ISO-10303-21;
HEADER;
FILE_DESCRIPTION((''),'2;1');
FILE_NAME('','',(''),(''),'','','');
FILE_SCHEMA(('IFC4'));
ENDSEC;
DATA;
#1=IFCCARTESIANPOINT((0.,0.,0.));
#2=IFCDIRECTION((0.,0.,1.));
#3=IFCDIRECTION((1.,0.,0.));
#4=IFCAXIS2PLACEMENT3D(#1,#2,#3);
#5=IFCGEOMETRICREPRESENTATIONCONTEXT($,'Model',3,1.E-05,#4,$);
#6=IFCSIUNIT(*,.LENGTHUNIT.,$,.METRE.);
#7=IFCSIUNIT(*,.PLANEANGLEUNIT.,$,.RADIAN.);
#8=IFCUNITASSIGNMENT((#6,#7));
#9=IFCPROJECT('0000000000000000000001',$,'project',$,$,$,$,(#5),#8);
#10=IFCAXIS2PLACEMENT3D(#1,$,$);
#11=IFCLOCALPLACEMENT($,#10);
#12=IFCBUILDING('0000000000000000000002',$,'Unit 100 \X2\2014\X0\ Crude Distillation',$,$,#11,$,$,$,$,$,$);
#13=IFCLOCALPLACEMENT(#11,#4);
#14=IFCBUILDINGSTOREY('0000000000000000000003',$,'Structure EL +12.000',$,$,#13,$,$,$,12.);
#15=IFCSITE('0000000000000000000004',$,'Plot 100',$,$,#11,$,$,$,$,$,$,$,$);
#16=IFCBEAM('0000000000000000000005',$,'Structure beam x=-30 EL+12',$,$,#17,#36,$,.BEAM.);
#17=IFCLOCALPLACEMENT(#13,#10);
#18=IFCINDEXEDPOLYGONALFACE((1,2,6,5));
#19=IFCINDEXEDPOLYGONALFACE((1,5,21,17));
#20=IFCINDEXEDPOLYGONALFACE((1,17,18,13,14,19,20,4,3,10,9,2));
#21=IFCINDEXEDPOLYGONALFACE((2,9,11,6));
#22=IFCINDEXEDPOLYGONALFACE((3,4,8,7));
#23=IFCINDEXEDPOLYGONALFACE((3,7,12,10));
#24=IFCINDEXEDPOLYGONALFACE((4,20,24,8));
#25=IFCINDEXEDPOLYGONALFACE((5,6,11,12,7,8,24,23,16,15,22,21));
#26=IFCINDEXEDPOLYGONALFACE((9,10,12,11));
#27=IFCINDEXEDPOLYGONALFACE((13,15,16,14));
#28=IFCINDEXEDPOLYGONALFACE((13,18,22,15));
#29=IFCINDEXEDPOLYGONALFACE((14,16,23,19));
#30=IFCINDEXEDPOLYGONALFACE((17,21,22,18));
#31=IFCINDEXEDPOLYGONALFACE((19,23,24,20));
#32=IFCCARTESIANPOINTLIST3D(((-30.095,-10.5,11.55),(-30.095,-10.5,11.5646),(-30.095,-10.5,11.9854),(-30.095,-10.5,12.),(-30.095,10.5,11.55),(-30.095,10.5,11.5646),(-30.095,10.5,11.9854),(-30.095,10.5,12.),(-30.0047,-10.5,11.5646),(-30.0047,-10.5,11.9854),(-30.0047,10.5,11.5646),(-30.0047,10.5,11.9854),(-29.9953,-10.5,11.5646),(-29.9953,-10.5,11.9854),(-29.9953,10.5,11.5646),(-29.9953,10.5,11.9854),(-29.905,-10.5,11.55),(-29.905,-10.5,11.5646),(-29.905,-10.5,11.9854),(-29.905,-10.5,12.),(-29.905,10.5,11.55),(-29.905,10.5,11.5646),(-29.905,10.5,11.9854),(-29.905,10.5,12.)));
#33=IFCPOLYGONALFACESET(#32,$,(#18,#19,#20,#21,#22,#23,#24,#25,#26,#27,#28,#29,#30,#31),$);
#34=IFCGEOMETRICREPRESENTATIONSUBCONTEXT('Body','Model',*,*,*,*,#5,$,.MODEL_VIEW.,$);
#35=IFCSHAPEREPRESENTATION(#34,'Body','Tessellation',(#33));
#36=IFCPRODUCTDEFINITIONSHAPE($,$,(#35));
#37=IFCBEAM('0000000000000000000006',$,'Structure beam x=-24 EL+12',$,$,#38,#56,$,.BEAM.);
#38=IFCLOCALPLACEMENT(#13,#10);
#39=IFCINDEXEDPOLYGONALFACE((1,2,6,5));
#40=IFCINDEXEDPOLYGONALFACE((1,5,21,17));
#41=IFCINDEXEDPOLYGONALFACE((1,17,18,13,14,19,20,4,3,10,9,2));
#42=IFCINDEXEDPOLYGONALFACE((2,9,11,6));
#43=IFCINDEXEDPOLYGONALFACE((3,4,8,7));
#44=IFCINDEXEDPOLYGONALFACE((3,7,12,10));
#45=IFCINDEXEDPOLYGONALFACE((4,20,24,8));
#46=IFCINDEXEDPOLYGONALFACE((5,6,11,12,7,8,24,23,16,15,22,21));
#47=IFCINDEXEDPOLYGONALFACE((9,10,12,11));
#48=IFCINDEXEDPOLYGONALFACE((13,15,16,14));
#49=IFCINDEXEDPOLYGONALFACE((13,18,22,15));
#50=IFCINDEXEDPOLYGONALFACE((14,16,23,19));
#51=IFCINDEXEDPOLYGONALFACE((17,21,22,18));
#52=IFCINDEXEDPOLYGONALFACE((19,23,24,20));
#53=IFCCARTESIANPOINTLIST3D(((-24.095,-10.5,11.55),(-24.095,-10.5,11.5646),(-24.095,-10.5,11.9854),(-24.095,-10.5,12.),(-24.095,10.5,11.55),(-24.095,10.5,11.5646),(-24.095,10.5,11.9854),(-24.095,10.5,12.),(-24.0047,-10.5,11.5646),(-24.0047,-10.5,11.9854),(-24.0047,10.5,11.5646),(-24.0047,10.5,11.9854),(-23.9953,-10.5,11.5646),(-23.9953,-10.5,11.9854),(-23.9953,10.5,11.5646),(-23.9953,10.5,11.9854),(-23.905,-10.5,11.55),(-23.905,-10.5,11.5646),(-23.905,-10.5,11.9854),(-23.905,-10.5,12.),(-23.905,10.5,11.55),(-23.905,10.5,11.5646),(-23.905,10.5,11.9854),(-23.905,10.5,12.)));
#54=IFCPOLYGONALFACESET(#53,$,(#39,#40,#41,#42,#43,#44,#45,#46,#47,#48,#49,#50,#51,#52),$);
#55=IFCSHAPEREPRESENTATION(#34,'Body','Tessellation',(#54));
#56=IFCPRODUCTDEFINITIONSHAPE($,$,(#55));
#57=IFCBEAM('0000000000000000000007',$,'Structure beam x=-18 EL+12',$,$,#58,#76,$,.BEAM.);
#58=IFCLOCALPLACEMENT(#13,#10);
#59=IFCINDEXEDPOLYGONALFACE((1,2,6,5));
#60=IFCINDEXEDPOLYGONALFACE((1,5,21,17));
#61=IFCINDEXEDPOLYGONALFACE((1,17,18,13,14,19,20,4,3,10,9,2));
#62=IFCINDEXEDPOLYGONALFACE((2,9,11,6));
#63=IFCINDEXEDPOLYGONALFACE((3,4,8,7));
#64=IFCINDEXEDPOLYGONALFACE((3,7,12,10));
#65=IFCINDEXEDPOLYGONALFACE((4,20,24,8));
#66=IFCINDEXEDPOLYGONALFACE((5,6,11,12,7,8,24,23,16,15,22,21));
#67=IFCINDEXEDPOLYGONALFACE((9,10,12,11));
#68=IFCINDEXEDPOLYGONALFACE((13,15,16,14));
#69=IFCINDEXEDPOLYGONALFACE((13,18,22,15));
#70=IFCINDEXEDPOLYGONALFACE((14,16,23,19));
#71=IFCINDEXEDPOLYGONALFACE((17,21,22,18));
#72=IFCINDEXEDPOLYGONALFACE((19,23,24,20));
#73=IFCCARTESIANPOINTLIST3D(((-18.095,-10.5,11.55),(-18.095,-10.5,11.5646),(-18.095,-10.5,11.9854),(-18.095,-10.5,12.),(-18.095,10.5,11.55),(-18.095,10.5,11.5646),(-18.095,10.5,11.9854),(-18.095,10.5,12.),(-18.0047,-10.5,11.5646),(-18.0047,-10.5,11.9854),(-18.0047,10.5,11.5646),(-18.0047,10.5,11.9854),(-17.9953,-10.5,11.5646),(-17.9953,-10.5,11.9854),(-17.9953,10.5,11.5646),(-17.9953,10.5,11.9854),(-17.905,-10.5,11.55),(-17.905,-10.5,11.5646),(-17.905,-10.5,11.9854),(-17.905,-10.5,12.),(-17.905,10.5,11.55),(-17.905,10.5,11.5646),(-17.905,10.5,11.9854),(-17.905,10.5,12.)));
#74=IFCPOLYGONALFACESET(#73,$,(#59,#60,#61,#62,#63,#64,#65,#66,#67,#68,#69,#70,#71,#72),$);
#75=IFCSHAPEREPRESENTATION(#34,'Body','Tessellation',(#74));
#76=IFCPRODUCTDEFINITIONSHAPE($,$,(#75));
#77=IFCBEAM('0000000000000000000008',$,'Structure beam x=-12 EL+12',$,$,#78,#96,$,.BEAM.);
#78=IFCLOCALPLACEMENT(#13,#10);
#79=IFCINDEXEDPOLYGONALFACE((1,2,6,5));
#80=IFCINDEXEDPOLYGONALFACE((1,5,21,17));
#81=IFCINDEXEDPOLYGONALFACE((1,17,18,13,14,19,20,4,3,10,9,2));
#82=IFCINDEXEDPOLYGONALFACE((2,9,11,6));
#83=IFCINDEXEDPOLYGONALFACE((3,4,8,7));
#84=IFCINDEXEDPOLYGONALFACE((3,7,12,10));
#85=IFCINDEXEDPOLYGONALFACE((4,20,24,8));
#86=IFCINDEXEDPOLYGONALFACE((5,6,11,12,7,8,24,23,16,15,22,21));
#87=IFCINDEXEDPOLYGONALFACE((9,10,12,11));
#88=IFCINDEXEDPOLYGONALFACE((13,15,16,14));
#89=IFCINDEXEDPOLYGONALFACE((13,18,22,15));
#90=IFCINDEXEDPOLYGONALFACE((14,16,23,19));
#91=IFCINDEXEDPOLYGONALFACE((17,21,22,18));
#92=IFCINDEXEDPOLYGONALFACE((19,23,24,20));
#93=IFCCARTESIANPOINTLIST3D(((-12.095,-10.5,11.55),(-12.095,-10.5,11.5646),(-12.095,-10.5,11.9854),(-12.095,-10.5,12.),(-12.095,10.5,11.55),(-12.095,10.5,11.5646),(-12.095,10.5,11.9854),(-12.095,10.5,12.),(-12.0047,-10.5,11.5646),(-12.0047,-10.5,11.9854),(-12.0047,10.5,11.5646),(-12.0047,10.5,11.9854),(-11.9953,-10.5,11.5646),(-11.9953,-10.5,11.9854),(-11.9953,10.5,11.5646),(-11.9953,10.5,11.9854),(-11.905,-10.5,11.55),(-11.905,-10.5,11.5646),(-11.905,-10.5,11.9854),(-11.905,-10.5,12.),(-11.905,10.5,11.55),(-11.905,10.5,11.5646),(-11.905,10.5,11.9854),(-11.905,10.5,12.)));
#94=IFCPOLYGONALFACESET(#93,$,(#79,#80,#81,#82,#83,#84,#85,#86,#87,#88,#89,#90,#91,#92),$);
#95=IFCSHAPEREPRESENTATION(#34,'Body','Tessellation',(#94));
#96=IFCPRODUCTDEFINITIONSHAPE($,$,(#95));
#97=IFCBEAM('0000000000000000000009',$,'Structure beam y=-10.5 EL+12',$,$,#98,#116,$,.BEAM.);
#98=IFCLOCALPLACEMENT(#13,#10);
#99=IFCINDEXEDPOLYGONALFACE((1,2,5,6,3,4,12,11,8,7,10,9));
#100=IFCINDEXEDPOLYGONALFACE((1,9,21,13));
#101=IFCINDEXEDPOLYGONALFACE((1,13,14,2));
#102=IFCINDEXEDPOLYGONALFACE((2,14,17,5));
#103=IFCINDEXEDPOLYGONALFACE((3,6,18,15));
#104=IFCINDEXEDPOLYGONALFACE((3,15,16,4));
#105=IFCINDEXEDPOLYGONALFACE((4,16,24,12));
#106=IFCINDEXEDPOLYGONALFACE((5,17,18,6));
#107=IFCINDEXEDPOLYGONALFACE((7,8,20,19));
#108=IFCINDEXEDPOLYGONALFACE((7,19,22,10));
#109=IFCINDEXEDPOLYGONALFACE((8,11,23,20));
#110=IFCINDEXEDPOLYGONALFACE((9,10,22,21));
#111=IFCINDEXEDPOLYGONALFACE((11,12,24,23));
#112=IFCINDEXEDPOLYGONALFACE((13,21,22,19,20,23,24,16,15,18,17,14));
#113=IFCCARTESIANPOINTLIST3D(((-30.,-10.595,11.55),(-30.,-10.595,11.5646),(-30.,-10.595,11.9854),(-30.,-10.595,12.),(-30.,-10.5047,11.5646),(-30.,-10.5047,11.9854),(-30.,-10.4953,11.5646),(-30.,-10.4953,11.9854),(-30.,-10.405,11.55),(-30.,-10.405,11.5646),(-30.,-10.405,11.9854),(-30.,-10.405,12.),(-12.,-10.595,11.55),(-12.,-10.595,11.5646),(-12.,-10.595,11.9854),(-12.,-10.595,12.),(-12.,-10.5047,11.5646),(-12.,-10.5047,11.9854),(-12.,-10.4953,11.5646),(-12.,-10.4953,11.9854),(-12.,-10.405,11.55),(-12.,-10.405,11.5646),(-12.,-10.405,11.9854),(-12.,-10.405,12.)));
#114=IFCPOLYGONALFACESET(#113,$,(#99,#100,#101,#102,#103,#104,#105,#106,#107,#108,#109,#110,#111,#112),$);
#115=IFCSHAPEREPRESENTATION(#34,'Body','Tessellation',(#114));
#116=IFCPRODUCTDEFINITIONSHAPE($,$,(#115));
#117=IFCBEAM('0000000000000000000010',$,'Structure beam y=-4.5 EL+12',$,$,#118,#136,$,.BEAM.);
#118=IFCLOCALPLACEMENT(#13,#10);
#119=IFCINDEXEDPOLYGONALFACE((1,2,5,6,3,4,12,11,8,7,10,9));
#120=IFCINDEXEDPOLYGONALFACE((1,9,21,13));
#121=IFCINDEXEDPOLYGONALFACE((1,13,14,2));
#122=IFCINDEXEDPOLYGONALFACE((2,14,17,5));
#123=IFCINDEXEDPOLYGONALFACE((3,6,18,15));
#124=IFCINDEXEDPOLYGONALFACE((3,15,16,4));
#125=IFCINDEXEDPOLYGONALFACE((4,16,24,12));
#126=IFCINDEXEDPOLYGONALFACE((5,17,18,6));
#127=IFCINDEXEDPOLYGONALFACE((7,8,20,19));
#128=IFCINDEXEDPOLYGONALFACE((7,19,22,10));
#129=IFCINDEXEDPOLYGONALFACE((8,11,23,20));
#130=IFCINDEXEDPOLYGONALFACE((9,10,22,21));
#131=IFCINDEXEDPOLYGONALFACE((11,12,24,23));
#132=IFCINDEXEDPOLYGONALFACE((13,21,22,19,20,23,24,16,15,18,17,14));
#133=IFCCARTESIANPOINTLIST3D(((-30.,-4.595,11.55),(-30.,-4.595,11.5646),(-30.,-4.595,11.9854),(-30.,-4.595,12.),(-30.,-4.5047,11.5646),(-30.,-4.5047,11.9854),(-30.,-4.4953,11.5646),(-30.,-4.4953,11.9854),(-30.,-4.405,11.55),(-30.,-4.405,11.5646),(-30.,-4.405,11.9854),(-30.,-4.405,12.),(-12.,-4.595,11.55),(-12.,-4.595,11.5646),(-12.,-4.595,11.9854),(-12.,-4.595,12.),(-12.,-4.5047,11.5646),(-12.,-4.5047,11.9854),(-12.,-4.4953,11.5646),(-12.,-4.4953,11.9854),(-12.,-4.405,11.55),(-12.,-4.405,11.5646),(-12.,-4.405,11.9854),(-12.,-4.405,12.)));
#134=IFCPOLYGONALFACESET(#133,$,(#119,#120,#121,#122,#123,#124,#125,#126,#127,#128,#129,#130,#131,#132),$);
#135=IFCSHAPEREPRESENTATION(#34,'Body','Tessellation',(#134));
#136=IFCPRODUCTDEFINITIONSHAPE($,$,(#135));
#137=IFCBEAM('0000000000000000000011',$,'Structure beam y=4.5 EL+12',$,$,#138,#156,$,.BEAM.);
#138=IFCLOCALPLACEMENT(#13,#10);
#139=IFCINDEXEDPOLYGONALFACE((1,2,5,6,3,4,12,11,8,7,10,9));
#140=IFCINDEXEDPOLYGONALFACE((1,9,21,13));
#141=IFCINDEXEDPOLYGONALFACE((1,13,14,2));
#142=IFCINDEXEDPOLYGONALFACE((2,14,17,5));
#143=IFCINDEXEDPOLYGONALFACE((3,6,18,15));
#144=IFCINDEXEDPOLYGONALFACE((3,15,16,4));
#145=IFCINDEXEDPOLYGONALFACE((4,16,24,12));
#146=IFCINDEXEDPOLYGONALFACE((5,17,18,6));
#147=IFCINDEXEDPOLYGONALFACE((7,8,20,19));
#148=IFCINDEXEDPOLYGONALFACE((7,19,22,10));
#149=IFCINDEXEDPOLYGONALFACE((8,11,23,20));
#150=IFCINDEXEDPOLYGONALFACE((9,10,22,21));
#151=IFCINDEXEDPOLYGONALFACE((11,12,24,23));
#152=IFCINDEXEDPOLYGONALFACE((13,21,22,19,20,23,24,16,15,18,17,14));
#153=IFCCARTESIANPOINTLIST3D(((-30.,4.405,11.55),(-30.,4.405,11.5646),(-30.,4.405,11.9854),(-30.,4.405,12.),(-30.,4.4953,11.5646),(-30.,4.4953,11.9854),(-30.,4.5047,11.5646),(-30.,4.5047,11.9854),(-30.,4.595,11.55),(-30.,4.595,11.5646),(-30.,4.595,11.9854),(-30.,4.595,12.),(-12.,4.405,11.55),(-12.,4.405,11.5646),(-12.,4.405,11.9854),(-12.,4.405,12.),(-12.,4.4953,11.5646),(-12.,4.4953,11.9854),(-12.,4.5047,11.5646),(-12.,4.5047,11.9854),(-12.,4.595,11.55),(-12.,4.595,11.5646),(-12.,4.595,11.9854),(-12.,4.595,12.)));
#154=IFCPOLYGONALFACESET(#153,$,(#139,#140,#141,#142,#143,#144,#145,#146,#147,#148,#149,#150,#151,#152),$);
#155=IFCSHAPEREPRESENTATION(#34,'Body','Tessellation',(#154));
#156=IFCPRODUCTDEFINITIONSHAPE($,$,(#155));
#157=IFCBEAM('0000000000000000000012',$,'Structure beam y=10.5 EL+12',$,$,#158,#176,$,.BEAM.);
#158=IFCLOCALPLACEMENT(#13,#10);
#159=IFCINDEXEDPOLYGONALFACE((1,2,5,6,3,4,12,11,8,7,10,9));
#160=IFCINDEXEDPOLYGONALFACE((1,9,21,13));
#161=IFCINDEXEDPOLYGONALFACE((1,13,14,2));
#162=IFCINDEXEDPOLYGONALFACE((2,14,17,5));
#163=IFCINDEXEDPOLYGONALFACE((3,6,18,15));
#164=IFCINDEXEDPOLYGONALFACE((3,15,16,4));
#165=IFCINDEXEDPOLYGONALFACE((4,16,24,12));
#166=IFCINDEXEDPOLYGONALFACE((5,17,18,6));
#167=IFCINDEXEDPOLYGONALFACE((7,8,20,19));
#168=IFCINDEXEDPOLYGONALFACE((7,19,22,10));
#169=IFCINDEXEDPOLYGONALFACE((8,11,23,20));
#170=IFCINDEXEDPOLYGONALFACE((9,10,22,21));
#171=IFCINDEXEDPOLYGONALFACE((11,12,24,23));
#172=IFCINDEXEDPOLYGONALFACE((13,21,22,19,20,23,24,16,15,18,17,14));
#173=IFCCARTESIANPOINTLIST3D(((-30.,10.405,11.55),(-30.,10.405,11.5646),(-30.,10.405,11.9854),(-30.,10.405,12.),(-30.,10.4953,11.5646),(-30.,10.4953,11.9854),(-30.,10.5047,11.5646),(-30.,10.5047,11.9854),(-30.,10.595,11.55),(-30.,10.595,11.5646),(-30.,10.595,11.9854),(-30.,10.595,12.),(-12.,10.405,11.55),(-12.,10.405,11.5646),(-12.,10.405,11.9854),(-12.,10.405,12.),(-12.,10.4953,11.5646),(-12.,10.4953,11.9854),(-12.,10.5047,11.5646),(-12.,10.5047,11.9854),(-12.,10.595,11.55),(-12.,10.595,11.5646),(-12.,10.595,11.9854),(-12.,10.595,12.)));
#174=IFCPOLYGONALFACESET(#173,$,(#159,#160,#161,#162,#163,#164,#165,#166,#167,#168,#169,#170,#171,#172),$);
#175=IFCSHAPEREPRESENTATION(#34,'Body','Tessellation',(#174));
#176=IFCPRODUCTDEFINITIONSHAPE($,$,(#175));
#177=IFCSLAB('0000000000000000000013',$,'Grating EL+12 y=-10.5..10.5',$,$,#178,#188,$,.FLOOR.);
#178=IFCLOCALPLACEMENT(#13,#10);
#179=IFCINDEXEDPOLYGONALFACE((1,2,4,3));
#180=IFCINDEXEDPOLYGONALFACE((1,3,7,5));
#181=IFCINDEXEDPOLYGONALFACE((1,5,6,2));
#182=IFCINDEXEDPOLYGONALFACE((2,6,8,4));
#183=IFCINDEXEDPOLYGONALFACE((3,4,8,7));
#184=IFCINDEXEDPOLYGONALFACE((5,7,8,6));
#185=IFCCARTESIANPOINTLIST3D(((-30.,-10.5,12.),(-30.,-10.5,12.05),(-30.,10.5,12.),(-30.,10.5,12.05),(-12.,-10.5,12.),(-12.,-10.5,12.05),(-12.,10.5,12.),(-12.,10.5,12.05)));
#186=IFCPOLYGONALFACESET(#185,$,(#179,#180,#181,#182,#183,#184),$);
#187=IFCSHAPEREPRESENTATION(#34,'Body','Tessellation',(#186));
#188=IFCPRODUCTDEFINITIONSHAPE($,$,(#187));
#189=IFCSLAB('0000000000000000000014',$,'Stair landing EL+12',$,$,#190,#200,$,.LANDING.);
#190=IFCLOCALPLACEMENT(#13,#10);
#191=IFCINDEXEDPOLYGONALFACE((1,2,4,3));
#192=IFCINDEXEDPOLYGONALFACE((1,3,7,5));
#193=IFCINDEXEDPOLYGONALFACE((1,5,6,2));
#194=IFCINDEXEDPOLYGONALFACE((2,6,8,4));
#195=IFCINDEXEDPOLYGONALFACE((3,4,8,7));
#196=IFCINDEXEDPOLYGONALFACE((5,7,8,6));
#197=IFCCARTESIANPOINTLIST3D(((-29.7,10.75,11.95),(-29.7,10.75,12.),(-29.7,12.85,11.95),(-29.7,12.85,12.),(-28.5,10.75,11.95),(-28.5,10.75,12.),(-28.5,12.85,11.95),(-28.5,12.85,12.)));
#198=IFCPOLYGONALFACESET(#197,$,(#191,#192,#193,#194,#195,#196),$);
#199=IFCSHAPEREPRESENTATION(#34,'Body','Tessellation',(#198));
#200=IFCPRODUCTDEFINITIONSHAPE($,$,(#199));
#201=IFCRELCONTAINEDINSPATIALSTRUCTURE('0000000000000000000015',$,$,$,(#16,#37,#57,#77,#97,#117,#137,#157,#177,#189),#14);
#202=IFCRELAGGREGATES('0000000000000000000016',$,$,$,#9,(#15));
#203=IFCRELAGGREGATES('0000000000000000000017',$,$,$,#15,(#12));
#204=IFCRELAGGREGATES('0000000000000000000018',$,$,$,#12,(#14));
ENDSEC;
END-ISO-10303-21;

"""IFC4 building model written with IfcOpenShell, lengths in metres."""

from ifc_helpers import new_model, si_unit, frame, origin, origin_with_axes, origin_2d, place, context, subcontext, project, spatial, rectangle, i_section, extrude, element, save


model = new_model("IFC4")

# Units and contexts
model_context = context("Model", 3, precision=1e-05, world=origin_with_axes())
body_context = subcontext(model_context, "Body", "Model", "MODEL_VIEW")
ifc_project = project(units=[si_unit("LENGTHUNIT", "METRE"), si_unit("PLANEANGLEUNIT", "RADIAN")], contexts=[model_context])

# Site, building, storey
placement = place(None, origin())
site = spatial("IfcSite", under=ifc_project, at=placement, Name="Plot 100")
building = spatial("IfcBuilding", under=site, at=placement, Name="Unit 100 — Crude Distillation")
storey_placement = place(placement, origin_with_axes())
storey = spatial("IfcBuildingStorey", under=building, at=storey_placement, Name="Structure EL +12.000", Elevation=12.0)

# Beams
beam_1_placement = place(storey_placement, origin_with_axes())
element("IfcBeam", 1, at=beam_1_placement, inside=storey, Name="Structure beam x=-30 EL+12", PredefinedType="BEAM", context=body_context, shape_type="SweptSolid", body=[
    extrude(i_section(OverallWidth=0.19, OverallDepth=0.45, WebThickness=0.0094, FlangeThickness=0.0146, at=origin_2d()), frame((-30.0, -10.5, 11.775), z_axis=(0.0, 1.0, 0.0), x_axis=(-1.0, 0.0, 0.0)), (0.0, 0.0, 1.0), 21.0),
])
beam_2_placement = place(storey_placement, origin_with_axes())
element("IfcBeam", 2, at=beam_2_placement, inside=storey, Name="Structure beam x=-24 EL+12", PredefinedType="BEAM", context=body_context, shape_type="SweptSolid", body=[
    extrude(i_section(OverallWidth=0.19, OverallDepth=0.45, WebThickness=0.0094, FlangeThickness=0.0146, at=origin_2d()), frame((-24.0, -10.5, 11.775), z_axis=(0.0, 1.0, 0.0), x_axis=(-1.0, 0.0, 0.0)), (0.0, 0.0, 1.0), 21.0),
])
beam_3_placement = place(storey_placement, origin_with_axes())
element("IfcBeam", 3, at=beam_3_placement, inside=storey, Name="Structure beam x=-18 EL+12", PredefinedType="BEAM", context=body_context, shape_type="SweptSolid", body=[
    extrude(i_section(OverallWidth=0.19, OverallDepth=0.45, WebThickness=0.0094, FlangeThickness=0.0146, at=origin_2d()), frame((-18.0, -10.5, 11.775), z_axis=(0.0, 1.0, 0.0), x_axis=(-1.0, 0.0, 0.0)), (0.0, 0.0, 1.0), 21.0),
])
beam_4_placement = place(storey_placement, origin_with_axes())
element("IfcBeam", 4, at=beam_4_placement, inside=storey, Name="Structure beam x=-12 EL+12", PredefinedType="BEAM", context=body_context, shape_type="SweptSolid", body=[
    extrude(i_section(OverallWidth=0.19, OverallDepth=0.45, WebThickness=0.0094, FlangeThickness=0.0146, at=origin_2d()), frame((-12.0, -10.5, 11.775), z_axis=(0.0, 1.0, 0.0), x_axis=(-1.0, 0.0, 0.0)), (0.0, 0.0, 1.0), 21.0),
])
beam_5_placement = place(storey_placement, origin_with_axes())
element("IfcBeam", 5, at=beam_5_placement, inside=storey, Name="Structure beam y=-10.5 EL+12", PredefinedType="BEAM", context=body_context, shape_type="SweptSolid", body=[
    extrude(i_section(OverallWidth=0.19, OverallDepth=0.45, WebThickness=0.0094, FlangeThickness=0.0146, at=origin_2d()), frame((-30.0, -10.5, 11.775), z_axis=(1.0, 0.0, 0.0), x_axis=(0.0, 1.0, 0.0)), (0.0, 0.0, 1.0), 18.0),
])
beam_6_placement = place(storey_placement, origin_with_axes())
element("IfcBeam", 6, at=beam_6_placement, inside=storey, Name="Structure beam y=-4.5 EL+12", PredefinedType="BEAM", context=body_context, shape_type="SweptSolid", body=[
    extrude(i_section(OverallWidth=0.19, OverallDepth=0.45, WebThickness=0.0094, FlangeThickness=0.0146, at=origin_2d()), frame((-30.0, -4.5, 11.775), z_axis=(1.0, 0.0, 0.0), x_axis=(0.0, 1.0, 0.0)), (0.0, 0.0, 1.0), 18.0),
])
beam_7_placement = place(storey_placement, origin_with_axes())
element("IfcBeam", 7, at=beam_7_placement, inside=storey, Name="Structure beam y=4.5 EL+12", PredefinedType="BEAM", context=body_context, shape_type="SweptSolid", body=[
    extrude(i_section(OverallWidth=0.19, OverallDepth=0.45, WebThickness=0.0094, FlangeThickness=0.0146, at=origin_2d()), frame((-30.0, 4.5, 11.775), z_axis=(1.0, 0.0, 0.0), x_axis=(0.0, 1.0, 0.0)), (0.0, 0.0, 1.0), 18.0),
])
beam_8_placement = place(storey_placement, origin_with_axes())
element("IfcBeam", 8, at=beam_8_placement, inside=storey, Name="Structure beam y=10.5 EL+12", PredefinedType="BEAM", context=body_context, shape_type="SweptSolid", body=[
    extrude(i_section(OverallWidth=0.19, OverallDepth=0.45, WebThickness=0.0094, FlangeThickness=0.0146, at=origin_2d()), frame((-30.0, 10.5, 11.775), z_axis=(1.0, 0.0, 0.0), x_axis=(0.0, 1.0, 0.0)), (0.0, 0.0, 1.0), 18.0),
])

# Slabs
slab_1_placement = place(storey_placement, origin_with_axes())
element("IfcSlab", 9, at=slab_1_placement, inside=storey, Name="Grating EL+12 y=-10.5..10.5", PredefinedType="FLOOR", context=body_context, shape_type="SweptSolid", body=[
    extrude(rectangle(XDim=18.0, YDim=21.0, at=origin_2d()), frame((-21.0, 0.0, 12.0), z_axis=(0.0, 0.0, 1.0), x_axis=(1.0, 0.0, 0.0)), (0.0, 0.0, 1.0), 0.05),
])
slab_2_placement = place(storey_placement, origin_with_axes())
element("IfcSlab", 10, at=slab_2_placement, inside=storey, Name="Stair landing EL+12", PredefinedType="LANDING", context=body_context, shape_type="SweptSolid", body=[
    extrude(rectangle(XDim=1.2, YDim=2.1, at=origin_2d()), frame((-29.1, 11.8, 11.95), z_axis=(0.0, 0.0, 1.0), x_axis=(1.0, 0.0, 0.0)), (0.0, 0.0, 1.0), 0.05),
])

save(model, "model.ifc")
